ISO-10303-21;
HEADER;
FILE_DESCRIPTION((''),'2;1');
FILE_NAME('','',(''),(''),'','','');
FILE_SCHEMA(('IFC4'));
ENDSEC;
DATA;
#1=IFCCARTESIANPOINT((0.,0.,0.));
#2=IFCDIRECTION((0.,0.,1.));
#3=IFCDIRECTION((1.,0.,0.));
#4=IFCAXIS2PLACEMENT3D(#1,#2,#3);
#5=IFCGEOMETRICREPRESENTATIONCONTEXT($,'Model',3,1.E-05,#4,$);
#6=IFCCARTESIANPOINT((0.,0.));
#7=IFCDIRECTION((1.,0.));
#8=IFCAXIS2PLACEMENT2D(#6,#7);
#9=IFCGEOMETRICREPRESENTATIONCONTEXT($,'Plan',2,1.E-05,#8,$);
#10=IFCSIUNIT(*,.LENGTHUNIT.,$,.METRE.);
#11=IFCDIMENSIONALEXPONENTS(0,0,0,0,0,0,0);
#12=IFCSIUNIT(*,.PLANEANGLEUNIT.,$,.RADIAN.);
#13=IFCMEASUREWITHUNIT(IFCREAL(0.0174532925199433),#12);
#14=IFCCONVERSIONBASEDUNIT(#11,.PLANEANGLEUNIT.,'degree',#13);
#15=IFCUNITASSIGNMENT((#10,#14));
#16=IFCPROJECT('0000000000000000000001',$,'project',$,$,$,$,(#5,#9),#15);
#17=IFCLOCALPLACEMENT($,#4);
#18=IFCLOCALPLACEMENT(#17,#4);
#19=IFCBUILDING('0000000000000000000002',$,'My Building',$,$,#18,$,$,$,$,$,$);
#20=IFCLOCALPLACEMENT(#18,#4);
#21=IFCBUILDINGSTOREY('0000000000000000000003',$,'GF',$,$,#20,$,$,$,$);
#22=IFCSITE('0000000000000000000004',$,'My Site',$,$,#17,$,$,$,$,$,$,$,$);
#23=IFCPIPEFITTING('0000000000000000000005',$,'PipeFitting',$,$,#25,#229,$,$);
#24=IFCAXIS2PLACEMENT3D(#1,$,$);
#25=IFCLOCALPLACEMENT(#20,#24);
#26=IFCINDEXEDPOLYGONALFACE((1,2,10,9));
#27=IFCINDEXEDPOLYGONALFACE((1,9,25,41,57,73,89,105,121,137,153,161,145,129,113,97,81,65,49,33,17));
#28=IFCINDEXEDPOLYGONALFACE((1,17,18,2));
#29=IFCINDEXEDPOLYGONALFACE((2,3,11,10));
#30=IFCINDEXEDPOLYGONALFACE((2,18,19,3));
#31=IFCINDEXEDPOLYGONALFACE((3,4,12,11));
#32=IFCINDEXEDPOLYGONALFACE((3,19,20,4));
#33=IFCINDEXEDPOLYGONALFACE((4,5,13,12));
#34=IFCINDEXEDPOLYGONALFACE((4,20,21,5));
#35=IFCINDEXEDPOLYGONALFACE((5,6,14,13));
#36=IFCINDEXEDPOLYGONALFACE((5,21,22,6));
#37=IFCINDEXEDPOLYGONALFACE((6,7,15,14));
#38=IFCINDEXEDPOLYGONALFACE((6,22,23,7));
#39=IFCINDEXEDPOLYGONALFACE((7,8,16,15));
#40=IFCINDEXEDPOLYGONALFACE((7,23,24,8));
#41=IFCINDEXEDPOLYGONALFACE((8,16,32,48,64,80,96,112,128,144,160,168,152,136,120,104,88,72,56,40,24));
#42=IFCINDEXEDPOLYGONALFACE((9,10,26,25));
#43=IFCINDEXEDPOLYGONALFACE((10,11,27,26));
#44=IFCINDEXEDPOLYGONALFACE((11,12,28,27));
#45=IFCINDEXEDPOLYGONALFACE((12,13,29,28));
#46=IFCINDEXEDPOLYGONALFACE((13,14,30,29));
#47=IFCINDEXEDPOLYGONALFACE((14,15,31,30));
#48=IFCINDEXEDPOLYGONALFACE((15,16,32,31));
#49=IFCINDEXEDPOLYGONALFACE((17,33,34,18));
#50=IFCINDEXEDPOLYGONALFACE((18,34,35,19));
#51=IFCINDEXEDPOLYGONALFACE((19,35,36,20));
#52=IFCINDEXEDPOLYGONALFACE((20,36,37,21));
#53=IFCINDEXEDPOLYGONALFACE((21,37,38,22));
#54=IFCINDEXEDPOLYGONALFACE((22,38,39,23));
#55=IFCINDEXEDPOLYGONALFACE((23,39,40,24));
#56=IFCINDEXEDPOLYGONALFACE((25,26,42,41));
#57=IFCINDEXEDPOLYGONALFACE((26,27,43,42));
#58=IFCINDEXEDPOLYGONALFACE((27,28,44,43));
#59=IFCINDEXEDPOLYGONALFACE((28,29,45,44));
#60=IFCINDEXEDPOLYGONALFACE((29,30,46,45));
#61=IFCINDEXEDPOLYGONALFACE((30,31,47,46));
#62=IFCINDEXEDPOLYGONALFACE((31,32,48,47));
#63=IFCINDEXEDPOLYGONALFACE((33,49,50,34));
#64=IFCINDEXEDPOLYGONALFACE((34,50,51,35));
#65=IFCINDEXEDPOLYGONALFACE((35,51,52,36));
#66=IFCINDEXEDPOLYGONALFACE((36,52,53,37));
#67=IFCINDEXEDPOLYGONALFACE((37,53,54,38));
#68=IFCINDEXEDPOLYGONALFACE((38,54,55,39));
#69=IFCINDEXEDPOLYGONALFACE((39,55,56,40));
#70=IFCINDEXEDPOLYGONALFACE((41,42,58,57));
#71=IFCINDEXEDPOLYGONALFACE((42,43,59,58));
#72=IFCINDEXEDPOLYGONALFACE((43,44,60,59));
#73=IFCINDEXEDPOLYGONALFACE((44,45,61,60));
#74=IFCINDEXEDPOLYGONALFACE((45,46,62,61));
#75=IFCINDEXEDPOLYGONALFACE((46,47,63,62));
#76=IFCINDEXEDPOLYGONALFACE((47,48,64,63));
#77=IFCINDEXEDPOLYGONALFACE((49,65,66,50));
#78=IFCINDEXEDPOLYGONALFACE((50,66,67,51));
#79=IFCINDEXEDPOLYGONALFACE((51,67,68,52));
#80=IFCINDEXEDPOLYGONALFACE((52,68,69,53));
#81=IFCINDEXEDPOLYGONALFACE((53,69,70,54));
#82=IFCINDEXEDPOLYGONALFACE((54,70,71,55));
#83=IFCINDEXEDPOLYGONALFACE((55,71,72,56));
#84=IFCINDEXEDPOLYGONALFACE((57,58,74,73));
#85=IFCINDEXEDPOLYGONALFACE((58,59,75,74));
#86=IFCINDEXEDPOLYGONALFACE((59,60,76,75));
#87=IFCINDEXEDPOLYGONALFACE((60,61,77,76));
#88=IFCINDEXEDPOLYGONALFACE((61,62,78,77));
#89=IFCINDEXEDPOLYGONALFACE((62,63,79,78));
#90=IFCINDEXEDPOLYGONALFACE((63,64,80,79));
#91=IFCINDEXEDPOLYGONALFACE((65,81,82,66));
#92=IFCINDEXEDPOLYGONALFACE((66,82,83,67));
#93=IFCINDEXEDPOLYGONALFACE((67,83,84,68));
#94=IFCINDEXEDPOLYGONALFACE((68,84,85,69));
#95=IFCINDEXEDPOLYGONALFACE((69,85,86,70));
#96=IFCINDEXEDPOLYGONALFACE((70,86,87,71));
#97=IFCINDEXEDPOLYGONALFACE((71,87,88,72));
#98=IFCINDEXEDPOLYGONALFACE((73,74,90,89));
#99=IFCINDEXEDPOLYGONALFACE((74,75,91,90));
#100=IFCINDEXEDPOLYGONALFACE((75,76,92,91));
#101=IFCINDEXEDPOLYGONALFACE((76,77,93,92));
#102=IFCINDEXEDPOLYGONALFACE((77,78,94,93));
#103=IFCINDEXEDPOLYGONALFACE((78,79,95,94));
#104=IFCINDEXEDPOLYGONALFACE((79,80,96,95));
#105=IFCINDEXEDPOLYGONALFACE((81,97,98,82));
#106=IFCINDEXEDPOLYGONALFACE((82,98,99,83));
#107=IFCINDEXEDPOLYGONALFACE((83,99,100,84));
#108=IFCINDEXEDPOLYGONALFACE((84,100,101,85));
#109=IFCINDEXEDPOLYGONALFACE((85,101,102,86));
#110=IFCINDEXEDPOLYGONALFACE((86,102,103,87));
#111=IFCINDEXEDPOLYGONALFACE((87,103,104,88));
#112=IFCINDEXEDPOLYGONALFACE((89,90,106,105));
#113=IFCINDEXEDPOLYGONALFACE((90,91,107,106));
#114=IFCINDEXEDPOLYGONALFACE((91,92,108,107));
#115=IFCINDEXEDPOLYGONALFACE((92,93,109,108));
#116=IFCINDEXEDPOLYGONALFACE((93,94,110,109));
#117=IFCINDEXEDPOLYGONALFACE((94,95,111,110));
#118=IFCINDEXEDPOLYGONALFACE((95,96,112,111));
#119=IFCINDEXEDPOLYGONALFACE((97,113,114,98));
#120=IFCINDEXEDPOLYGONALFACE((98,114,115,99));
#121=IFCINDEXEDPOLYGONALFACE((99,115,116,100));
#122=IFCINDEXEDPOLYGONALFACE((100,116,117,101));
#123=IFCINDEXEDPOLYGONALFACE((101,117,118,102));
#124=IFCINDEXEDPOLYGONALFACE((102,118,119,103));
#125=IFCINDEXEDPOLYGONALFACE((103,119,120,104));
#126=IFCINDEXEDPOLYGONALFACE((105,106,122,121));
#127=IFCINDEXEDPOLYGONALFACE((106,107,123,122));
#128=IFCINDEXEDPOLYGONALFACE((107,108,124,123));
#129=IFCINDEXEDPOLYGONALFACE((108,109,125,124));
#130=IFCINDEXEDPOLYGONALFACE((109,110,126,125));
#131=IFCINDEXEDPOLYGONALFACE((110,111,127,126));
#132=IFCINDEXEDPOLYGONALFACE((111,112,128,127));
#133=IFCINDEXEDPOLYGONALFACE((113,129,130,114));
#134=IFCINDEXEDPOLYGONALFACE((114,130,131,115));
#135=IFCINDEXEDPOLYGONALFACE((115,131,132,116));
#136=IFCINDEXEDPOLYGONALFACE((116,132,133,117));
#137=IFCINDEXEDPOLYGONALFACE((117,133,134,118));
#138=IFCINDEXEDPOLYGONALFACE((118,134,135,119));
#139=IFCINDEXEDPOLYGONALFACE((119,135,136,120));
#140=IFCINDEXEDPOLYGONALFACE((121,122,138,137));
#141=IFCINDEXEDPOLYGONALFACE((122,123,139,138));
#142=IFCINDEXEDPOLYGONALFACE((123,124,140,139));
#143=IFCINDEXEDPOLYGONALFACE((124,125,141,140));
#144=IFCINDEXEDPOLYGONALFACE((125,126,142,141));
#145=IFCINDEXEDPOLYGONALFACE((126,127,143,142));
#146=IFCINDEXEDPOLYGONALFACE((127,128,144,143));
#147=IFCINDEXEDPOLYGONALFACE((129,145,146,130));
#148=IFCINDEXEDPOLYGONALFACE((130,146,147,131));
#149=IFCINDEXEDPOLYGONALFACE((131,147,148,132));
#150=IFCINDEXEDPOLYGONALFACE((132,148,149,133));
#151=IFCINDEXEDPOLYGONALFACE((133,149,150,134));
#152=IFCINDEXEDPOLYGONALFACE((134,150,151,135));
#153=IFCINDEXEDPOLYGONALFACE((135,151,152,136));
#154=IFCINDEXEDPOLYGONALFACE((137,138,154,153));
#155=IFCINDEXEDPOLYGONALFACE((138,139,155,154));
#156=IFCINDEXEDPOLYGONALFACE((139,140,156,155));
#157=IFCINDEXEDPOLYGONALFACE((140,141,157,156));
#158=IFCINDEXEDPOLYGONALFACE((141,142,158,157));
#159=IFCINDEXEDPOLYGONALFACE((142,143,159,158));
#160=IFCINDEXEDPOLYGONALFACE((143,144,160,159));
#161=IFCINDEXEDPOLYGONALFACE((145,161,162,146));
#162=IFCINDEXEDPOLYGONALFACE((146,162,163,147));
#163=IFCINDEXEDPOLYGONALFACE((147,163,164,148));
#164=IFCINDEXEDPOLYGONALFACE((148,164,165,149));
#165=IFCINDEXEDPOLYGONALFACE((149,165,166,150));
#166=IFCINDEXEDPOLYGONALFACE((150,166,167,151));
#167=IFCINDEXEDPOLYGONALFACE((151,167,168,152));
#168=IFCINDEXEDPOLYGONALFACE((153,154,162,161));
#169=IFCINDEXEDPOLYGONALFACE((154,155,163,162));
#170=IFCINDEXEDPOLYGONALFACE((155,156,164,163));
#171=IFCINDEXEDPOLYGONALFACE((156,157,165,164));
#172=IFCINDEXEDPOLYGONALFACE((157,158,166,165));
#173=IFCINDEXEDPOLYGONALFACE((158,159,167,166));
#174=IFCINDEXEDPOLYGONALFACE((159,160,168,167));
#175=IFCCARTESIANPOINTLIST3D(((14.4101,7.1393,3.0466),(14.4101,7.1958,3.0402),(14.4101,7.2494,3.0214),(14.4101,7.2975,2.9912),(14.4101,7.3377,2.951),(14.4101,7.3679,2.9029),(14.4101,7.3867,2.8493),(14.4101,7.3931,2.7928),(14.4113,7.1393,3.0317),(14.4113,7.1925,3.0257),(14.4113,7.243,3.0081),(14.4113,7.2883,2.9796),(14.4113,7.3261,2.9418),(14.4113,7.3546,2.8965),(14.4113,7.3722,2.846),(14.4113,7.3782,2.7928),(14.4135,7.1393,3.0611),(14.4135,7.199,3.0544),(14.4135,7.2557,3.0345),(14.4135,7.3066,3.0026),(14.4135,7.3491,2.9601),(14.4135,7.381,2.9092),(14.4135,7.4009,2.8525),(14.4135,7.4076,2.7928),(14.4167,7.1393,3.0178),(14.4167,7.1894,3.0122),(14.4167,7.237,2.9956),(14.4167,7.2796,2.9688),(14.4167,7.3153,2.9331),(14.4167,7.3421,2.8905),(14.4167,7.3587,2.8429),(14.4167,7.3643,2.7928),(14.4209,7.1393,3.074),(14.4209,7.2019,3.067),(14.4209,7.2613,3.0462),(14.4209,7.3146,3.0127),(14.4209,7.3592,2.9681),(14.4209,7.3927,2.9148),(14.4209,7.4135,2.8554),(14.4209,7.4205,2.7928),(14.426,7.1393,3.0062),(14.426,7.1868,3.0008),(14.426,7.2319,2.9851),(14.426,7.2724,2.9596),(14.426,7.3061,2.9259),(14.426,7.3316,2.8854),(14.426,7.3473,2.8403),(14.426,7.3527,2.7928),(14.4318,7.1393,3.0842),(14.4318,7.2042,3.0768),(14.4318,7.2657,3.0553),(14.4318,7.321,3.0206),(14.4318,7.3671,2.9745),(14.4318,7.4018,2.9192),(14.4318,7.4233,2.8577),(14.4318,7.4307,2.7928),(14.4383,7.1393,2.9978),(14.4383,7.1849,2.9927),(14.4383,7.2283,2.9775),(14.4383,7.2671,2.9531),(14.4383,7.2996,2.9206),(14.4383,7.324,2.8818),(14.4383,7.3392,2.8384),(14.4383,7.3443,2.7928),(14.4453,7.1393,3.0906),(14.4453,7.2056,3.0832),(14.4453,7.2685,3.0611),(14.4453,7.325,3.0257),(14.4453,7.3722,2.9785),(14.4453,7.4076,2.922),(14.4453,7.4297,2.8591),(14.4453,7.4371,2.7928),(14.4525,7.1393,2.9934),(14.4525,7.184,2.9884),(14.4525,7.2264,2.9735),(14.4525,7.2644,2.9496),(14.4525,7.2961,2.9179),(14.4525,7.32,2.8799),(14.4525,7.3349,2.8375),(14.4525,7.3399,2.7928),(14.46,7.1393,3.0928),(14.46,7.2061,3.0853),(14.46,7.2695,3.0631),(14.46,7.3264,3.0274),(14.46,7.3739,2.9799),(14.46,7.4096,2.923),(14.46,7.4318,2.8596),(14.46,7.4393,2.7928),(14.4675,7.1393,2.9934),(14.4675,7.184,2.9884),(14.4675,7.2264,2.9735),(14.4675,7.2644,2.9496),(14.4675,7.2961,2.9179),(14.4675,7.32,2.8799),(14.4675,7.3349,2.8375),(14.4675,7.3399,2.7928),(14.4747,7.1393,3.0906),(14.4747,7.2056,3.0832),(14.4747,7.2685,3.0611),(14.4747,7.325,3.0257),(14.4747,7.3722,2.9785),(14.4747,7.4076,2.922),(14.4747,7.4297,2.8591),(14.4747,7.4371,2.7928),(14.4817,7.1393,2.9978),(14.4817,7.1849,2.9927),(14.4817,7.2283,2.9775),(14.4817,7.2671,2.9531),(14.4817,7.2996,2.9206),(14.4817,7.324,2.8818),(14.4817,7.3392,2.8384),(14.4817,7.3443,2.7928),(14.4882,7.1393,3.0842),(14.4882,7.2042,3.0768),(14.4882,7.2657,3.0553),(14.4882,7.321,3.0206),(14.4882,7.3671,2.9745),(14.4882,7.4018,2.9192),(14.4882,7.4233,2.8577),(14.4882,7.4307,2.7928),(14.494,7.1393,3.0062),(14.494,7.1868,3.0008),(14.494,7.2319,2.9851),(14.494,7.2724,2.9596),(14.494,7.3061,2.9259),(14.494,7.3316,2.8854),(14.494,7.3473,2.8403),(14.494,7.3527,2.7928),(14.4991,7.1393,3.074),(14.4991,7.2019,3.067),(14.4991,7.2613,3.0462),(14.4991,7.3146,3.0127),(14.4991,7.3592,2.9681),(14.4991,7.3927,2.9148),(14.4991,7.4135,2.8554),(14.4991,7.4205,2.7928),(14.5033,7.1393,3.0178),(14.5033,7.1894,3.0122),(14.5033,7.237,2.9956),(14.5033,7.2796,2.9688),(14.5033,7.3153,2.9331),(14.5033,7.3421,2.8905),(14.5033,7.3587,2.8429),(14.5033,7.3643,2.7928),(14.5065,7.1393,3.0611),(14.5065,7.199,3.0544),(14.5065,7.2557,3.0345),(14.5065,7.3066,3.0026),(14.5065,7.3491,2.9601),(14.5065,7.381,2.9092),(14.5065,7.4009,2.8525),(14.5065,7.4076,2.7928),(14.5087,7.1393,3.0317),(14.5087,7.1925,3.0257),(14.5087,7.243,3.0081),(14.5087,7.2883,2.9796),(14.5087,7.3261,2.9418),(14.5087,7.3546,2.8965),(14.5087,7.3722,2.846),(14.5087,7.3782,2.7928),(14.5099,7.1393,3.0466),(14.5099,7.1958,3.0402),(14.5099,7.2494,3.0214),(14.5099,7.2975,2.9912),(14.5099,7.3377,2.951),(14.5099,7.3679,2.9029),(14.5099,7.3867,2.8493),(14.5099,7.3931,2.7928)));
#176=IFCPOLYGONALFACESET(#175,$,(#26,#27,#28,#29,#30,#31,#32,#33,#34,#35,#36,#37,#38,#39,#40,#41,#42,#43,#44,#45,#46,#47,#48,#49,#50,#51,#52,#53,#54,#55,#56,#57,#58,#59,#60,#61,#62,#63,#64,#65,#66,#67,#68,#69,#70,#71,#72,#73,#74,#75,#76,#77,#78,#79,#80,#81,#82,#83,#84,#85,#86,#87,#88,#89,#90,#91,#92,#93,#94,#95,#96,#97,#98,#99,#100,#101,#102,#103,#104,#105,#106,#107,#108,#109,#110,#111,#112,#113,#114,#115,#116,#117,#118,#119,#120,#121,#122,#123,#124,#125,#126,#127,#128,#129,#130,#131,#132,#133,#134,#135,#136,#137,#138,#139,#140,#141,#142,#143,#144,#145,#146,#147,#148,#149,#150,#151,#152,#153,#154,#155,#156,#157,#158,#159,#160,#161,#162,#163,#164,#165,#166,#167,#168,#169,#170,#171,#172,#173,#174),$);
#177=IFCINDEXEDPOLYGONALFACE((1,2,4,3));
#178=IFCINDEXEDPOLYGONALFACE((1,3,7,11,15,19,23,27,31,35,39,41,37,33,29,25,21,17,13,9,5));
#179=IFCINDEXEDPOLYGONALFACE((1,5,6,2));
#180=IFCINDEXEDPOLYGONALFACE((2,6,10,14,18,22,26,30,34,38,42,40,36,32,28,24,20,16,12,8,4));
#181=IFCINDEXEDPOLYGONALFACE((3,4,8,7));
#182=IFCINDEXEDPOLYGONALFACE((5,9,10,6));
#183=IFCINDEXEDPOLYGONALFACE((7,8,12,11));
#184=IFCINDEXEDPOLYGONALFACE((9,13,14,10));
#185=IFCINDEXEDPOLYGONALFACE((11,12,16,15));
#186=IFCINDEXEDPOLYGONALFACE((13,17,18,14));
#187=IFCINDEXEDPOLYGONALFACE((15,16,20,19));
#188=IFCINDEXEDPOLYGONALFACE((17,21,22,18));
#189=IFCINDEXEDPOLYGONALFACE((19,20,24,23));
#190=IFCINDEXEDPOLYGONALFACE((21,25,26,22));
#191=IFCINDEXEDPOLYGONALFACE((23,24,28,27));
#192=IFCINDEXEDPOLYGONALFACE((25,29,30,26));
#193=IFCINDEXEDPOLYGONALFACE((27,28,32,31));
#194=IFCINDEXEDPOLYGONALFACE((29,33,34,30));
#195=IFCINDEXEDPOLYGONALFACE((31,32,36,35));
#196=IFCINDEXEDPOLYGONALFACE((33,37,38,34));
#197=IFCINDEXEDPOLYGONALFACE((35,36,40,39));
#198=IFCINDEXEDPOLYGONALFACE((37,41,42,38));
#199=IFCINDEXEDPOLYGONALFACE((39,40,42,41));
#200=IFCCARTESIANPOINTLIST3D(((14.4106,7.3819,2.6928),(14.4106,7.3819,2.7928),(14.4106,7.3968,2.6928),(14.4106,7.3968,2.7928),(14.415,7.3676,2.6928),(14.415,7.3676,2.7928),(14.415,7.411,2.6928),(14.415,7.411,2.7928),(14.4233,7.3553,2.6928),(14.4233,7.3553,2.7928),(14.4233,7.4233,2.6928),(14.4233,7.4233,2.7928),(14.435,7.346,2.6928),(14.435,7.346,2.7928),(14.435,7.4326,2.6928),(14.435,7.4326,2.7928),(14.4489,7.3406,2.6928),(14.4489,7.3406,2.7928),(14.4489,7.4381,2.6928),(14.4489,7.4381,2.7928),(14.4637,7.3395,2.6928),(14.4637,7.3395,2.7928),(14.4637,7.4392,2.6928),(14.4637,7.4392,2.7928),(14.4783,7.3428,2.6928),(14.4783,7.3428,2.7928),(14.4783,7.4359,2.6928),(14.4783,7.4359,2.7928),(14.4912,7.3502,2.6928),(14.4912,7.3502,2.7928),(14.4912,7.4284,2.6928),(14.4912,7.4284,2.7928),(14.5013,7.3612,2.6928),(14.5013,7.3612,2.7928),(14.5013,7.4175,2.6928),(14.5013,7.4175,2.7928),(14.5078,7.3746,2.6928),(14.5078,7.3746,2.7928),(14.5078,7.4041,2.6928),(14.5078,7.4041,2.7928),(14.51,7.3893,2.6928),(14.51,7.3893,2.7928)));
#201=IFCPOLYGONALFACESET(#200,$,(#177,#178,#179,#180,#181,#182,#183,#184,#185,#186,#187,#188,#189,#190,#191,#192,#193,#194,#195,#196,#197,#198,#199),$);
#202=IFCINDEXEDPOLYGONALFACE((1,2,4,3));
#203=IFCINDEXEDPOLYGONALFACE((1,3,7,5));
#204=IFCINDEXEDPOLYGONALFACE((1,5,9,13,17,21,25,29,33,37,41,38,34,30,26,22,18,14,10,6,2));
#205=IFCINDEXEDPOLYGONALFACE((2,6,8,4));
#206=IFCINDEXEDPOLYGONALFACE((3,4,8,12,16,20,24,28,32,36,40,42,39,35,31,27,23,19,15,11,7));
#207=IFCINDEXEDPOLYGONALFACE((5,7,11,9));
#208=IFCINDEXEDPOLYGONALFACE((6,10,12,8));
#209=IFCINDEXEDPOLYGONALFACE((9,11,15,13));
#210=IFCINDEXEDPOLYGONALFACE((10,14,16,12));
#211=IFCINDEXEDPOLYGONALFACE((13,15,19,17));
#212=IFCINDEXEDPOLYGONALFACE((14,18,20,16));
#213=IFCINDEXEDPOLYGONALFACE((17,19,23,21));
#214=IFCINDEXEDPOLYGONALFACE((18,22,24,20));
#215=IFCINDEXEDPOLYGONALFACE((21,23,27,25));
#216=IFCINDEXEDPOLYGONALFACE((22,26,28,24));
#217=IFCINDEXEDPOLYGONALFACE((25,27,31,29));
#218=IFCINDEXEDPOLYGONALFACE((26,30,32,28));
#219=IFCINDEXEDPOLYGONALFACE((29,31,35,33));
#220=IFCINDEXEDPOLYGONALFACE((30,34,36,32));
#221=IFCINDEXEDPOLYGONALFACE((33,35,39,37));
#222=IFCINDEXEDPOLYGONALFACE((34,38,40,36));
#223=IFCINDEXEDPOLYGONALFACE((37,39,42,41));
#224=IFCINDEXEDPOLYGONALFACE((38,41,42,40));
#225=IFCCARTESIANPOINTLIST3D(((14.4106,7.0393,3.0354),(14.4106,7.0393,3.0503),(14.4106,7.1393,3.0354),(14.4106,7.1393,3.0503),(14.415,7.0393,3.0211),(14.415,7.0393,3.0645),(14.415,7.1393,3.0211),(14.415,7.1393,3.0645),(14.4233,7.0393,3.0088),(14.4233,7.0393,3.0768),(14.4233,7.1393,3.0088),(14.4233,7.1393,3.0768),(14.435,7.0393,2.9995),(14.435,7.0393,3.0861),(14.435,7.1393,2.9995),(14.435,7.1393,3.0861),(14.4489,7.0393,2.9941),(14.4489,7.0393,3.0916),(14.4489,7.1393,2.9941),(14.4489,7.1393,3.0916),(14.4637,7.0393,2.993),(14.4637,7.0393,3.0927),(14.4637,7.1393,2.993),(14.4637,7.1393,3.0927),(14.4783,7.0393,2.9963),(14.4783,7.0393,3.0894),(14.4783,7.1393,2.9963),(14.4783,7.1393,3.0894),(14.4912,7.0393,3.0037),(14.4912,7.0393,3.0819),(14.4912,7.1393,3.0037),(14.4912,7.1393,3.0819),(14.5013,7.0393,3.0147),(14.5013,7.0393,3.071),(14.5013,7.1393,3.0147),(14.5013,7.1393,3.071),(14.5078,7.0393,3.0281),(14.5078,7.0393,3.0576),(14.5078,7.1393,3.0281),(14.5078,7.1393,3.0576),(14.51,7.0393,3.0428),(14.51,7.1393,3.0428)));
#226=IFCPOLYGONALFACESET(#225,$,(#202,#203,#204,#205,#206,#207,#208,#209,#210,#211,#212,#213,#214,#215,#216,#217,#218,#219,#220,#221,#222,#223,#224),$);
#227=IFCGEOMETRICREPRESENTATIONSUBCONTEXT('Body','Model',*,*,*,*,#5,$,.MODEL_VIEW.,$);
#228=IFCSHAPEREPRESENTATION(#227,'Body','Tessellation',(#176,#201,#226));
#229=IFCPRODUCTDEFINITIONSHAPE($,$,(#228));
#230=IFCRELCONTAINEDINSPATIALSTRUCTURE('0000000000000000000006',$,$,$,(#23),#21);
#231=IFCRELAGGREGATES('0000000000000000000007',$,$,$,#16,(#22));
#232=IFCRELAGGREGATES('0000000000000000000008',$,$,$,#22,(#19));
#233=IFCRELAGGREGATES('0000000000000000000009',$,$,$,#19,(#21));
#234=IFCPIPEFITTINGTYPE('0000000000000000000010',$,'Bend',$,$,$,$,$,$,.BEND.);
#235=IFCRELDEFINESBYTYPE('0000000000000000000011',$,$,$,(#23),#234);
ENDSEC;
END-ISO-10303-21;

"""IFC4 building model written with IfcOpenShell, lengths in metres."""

from ifc_helpers import new_model, entity, si_unit, converted_unit, frame, origin_with_axes, origin_2d_with_axis, place, context, subcontext, project, spatial, line, indexed_curve, circle, outline, extrude, source, transform, mapped, type_object, type_shapes, element, save


model = new_model("IFC4")

# Units and contexts
model_context = context("Model", 3, precision=1e-05, world=origin_with_axes())
plan_context = context("Plan", 2, precision=1e-05, world=origin_2d_with_axis())
body_context = subcontext(model_context, "Body", "Model", "MODEL_VIEW")
ifc_project = project(units=[si_unit("LENGTHUNIT", "METRE"), converted_unit("PLANEANGLEUNIT", "degree", entity("IfcReal", 0.0174532925199433), si_unit("PLANEANGLEUNIT", "RADIAN"), dimensions=[0, 0, 0, 0, 0, 0, 0])], contexts=[model_context, plan_context])

# Site, building, storey
site_placement = place(None, origin_with_axes())
site = spatial("IfcSite", under=ifc_project, at=site_placement, Name="My Site")
building_placement = place(site_placement, origin_with_axes())
building = spatial("IfcBuilding", under=site, at=building_placement, Name="My Building")
storey_placement = place(building_placement, origin_with_axes())
storey = spatial("IfcBuildingStorey", under=building, at=storey_placement, Name="GF")

# Pipe fitting, opening
pipe_fitting_type = type_object("IfcPipeFittingType", Name="Bend", PredefinedType="BEND")
shared_shape = source(origin_with_axes(), body_context, "Body", "SolidModel", [
    entity("IfcSweptDiskSolid", entity("IfcIndexedPolyCurve", entity("IfcCartesianPointList3D", [[0.0, 0.0, 0.1], [0.0, -0.0732, 0.2768], [0.0, -0.25, 0.35]]), [entity("IfcArcIndex", [1, 2, 3])]), 0.05),
    extrude(circle(Radius=0.05), origin_with_axes(), (0.0, 0.0, 1.0), 0.1),
    extrude(circle(Radius=0.05), frame((0.0, -0.25, 0.35), z_axis=(0.0, -1.0, 0.0), x_axis=(1.0, 0.0, 0.0)), (0.0, 0.0, 1.0), 0.1),
])
type_shapes(pipe_fitting_type, [shared_shape])
pipe_fitting_1_placement = place(storey_placement, frame((14.46, 7.3893, 2.6928), z_axis=(0.0, 0.0, 1.0), x_axis=(1.0, 0.0, 0.0)))
pipe_fitting_1 = element("IfcPipeFitting", 1, at=pipe_fitting_1_placement, inside=storey, type_object=pipe_fitting_type, Name="PipeFitting", context=body_context, shape_type="MappedRepresentation", body=[
    mapped(shared_shape, transform((0.0, 0.0, 0.0), x_axis=(1.0, 0.0, 0.0), y_axis=(0.0, 1.0, 0.0), z_axis=(0.0, 0.0, 1.0), scale=1.0)),
])
opening_1_placement = place(pipe_fitting_1_placement, frame((-14.46, -7.3893, -2.6928), z_axis=(0.0, 0.0, 1.0), x_axis=(1.0, 0.0, 0.0)))
element("IfcOpeningElement", 2, at=opening_1_placement, cuts=pipe_fitting_1, PredefinedType="OPENING", context=body_context, shape_type="SweptSolid", body=[
    extrude(outline(indexed_curve([(0.0, 0.0), (0.5, 0.0), (0.5, 0.5), (0.0, 0.5)], segments=[line(1, 2, 3, 4, 1)])), origin_with_axes(), (0.0, 0.0, 1.0), 0.5),
])

save(model, "model.ifc")
